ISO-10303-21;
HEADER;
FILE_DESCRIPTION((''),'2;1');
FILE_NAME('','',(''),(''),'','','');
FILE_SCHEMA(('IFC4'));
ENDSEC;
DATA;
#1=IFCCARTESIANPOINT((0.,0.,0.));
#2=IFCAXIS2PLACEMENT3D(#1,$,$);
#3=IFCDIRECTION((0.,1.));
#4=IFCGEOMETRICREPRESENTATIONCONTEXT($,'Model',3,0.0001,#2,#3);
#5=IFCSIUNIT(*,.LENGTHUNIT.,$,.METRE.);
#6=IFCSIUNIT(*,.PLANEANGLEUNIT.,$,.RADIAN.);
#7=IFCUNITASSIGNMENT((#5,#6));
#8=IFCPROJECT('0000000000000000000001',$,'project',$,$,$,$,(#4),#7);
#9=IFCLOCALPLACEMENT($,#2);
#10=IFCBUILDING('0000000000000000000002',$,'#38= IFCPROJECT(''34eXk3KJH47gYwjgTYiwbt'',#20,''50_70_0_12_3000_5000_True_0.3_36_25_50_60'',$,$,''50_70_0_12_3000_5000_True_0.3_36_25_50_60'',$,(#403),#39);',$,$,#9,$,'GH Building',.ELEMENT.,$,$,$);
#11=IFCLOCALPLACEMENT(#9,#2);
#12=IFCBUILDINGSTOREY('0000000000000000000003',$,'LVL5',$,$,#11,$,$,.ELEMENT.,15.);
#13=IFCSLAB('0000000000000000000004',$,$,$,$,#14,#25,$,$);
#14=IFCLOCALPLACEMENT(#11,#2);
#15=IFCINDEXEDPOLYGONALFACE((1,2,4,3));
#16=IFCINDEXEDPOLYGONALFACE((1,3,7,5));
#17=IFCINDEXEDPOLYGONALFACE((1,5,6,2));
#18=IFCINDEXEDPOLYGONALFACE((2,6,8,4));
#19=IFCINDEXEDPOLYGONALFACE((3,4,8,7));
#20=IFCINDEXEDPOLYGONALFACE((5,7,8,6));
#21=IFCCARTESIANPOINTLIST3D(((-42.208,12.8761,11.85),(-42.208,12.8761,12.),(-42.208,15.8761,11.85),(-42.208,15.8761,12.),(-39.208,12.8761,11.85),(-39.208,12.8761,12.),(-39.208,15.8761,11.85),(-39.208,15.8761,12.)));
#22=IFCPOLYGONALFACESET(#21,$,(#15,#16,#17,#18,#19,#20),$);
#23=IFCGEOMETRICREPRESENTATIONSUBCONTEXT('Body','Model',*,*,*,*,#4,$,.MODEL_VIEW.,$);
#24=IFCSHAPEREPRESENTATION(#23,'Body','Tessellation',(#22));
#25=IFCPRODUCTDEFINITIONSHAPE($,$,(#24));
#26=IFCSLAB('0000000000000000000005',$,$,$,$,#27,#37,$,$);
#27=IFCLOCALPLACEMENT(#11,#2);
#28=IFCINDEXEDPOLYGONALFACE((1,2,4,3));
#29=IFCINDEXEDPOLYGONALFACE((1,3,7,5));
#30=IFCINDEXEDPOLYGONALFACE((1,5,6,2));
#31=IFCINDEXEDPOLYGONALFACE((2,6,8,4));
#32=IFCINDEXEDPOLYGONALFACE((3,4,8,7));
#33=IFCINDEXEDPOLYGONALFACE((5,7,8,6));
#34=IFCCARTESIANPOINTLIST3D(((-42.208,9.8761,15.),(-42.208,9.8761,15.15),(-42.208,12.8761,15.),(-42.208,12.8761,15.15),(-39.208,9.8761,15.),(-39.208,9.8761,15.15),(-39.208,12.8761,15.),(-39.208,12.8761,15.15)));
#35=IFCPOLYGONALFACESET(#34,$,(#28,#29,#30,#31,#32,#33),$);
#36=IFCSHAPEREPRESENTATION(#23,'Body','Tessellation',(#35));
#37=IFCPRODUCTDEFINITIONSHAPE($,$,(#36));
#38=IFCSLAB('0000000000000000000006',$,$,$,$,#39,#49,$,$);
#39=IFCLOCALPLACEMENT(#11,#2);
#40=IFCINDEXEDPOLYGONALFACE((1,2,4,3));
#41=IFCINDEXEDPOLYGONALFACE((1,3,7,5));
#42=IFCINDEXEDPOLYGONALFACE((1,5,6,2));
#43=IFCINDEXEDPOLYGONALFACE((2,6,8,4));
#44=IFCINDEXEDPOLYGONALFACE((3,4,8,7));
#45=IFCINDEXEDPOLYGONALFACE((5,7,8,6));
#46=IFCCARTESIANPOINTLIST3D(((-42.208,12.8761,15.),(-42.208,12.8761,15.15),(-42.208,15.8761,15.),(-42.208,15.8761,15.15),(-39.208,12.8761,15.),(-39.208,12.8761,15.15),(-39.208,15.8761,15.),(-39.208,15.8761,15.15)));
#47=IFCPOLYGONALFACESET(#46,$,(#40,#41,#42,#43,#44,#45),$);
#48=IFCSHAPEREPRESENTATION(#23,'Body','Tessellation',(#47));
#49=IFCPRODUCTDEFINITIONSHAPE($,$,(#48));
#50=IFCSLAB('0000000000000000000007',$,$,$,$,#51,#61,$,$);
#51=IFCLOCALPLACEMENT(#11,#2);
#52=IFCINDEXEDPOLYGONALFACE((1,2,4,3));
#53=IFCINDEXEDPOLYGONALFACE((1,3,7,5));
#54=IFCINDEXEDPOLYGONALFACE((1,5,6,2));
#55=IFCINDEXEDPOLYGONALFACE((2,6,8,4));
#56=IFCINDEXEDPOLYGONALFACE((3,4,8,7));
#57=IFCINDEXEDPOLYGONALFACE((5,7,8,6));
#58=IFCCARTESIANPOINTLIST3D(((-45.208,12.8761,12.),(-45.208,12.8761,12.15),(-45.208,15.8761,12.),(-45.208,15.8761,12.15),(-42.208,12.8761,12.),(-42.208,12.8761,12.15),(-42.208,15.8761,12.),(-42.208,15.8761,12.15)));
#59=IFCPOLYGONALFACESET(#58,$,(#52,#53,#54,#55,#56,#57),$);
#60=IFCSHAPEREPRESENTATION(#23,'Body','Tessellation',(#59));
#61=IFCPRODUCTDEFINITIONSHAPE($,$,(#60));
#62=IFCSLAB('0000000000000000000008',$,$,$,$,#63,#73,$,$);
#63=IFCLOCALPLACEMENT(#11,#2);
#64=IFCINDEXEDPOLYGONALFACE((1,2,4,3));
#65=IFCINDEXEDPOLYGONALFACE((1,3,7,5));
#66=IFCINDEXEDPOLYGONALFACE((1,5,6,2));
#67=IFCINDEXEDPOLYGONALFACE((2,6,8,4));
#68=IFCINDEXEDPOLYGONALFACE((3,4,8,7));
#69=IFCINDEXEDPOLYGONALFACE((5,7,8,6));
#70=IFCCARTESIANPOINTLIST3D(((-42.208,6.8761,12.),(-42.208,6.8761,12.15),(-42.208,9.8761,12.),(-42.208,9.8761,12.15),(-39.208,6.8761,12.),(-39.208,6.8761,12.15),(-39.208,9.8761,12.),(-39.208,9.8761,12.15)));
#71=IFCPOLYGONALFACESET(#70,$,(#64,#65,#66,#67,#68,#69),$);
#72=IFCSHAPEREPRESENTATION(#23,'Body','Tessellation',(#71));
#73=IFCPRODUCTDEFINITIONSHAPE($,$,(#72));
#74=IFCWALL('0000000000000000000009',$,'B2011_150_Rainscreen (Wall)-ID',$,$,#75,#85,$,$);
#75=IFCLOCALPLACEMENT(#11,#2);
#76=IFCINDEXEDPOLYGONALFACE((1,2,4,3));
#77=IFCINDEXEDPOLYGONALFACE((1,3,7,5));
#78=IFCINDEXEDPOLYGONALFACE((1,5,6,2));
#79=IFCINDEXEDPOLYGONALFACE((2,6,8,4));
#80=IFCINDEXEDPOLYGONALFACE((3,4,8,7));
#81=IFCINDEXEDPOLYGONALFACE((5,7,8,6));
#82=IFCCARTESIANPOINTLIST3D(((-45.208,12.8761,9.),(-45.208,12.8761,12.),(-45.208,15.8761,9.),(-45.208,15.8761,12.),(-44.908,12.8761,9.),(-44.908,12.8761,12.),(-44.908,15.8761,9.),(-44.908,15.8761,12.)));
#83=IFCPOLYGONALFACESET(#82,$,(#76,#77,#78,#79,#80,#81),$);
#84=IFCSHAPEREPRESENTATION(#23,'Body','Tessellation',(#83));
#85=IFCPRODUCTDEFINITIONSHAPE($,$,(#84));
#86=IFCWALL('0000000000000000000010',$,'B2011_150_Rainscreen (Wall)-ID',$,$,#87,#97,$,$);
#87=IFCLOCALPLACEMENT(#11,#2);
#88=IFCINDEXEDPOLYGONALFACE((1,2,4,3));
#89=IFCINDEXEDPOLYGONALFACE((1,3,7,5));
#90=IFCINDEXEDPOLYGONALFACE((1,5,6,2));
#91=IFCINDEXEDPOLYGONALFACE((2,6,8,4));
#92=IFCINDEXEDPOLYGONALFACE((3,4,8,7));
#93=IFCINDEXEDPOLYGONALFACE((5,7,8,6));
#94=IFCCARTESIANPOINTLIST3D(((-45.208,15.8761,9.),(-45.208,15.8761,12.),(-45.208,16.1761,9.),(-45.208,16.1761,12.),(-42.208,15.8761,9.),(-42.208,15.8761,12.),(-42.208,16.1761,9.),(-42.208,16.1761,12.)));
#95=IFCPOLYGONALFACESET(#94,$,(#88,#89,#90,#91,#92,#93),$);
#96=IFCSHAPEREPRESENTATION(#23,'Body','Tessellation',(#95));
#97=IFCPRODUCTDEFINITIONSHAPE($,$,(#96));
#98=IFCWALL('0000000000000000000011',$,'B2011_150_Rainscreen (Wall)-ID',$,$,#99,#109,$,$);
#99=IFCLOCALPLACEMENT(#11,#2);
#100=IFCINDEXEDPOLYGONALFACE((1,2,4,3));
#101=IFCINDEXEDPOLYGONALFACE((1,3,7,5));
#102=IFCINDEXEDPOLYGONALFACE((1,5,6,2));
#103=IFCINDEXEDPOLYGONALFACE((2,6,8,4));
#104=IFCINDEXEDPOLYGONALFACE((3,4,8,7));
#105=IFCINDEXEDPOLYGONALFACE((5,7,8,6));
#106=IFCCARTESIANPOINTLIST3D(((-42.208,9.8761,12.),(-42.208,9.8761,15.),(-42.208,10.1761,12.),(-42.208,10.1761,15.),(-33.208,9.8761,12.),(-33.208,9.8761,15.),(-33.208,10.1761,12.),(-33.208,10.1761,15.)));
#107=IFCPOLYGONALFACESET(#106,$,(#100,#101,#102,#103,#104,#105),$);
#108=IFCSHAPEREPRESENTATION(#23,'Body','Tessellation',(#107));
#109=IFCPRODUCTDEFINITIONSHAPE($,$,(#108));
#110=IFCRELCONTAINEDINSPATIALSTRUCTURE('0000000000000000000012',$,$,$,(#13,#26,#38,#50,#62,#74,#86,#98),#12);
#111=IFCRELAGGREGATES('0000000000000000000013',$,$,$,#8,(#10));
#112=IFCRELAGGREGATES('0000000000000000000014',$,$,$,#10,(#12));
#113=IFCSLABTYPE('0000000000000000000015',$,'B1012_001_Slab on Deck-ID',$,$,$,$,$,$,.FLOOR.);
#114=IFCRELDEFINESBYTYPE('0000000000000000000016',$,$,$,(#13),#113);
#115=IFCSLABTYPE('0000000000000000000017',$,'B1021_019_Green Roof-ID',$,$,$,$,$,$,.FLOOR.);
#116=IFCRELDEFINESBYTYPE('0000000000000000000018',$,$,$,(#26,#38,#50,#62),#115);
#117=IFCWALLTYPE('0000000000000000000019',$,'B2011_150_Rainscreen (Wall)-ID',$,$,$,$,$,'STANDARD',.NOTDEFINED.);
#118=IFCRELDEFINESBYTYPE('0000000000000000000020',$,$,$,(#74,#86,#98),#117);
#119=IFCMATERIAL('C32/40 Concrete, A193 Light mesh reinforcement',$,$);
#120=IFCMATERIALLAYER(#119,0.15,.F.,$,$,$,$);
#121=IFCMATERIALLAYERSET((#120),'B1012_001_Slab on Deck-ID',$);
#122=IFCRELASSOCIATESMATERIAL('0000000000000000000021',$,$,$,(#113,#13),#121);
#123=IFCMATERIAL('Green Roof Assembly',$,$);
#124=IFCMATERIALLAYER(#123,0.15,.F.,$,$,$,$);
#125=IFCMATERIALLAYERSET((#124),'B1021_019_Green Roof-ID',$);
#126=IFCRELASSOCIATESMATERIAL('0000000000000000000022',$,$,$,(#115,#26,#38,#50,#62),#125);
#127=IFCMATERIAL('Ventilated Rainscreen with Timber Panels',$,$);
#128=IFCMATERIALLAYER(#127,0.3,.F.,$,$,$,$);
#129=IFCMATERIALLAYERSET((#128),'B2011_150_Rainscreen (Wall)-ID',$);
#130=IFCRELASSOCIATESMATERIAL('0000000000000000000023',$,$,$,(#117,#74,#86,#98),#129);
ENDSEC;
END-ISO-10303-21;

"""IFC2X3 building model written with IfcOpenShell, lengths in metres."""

from ifc_helpers import new_model, si_unit, direction, frame, frame_2d, origin, place, context, subcontext, project, spatial, polyline, rectangle, outline, extrude, material, layer, layer_set, layer_usage, type_object, element, save


model = new_model("IFC2X3")

# Units and contexts
model_context = context("Model", 3, precision=0.0001, world=origin(), true_north=direction((0.0, 1.0)))
body_context = subcontext(model_context, "Body", "Model", "MODEL_VIEW")
ifc_project = project(units=[si_unit("LENGTHUNIT", "METRE"), si_unit("PLANEANGLEUNIT", "RADIAN")], contexts=[model_context])

# Building, storey
building_placement = place(None, origin())
building = spatial("IfcBuilding", under=ifc_project, at=building_placement, Name="#38= IFCPROJECT('34eXk3KJH47gYwjgTYiwbt',#20,'50_70_0_12_3000_5000_True_0.3_36_25_50_60',$,$,'50_70_0_12_3000_5000_True_0.3_36_25_50_60',$,(#403),#39);", LongName="GH Building", CompositionType="ELEMENT")
storey_placement = place(building_placement, origin())
storey = spatial("IfcBuildingStorey", under=building, at=storey_placement, Name="LVL5", CompositionType="ELEMENT", Elevation=15.0)

# Slabs
ifc_material_1 = material(Name="C32/40 Concrete, A193 Light mesh reinforcement")
ifc_layer_1 = layer(ifc_material_1, 0.15, ventilated=False)
ifc_layer_set_1 = layer_set([ifc_layer_1], Name="B1012_001_Slab on Deck-ID")
slab_type_1 = type_object("IfcSlabType", Name="B1012_001_Slab on Deck-ID", PredefinedType="FLOOR", material=ifc_layer_set_1)
ifc_layer_usage_1 = layer_usage(ifc_layer_set_1, "AXIS3", "NEGATIVE", -0.15)
slab_1_placement = place(storey_placement, frame((-40.708, 14.3761, 11.85)))
element("IfcSlab", 1, at=slab_1_placement, inside=storey, type_object=slab_type_1, material=ifc_layer_usage_1, context=body_context, shape_type="SweptSolid", body=[
    extrude(outline(polyline([(-1.5, 1.5), (1.5, 1.5), (1.5, -1.5), (-1.5, -1.5), (-1.5, 1.5)])), origin(), (0.0, 0.0, 1.0), 0.15),
])
ifc_material_2 = material(Name="Green Roof Assembly")
ifc_layer_2 = layer(ifc_material_2, 0.15, ventilated=False)
ifc_layer_set_2 = layer_set([ifc_layer_2], Name="B1021_019_Green Roof-ID")
ifc_layer_usage_2 = layer_usage(ifc_layer_set_2, "AXIS3", "NEGATIVE", -0.15)
slab_type_2 = type_object("IfcSlabType", Name="B1021_019_Green Roof-ID", PredefinedType="FLOOR", material=ifc_layer_set_2)
slab_2_placement = place(storey_placement, frame((-40.708, 11.3761, 15.0)))
element("IfcSlab", 2, at=slab_2_placement, inside=storey, type_object=slab_type_2, material=ifc_layer_usage_2, context=body_context, shape_type="SweptSolid", body=[
    extrude(outline(polyline([(-1.5, -1.5), (-1.5, 1.5), (1.5, 1.5), (1.5, -1.5), (-1.5, -1.5)])), origin(), (0.0, 0.0, 1.0), 0.15),
])
ifc_layer_usage_3 = layer_usage(ifc_layer_set_2, "AXIS3", "NEGATIVE", -0.15)
slab_3_placement = place(storey_placement, frame((-40.708, 14.3761, 15.0)))
element("IfcSlab", 3, at=slab_3_placement, inside=storey, type_object=slab_type_2, material=ifc_layer_usage_3, context=body_context, shape_type="SweptSolid", body=[
    extrude(outline(polyline([(-1.5, -1.5), (-1.5, 1.5), (1.5, 1.5), (1.5, -1.5), (-1.5, -1.5)])), origin(), (0.0, 0.0, 1.0), 0.15),
])
ifc_layer_usage_4 = layer_usage(ifc_layer_set_2, "AXIS3", "NEGATIVE", -0.15)
slab_4_placement = place(storey_placement, frame((-43.708, 14.3761, 12.0)))
element("IfcSlab", 4, at=slab_4_placement, inside=storey, type_object=slab_type_2, material=ifc_layer_usage_4, context=body_context, shape_type="SweptSolid", body=[
    extrude(outline(polyline([(-1.5, 1.5), (1.5, 1.5), (1.5, -1.5), (-1.5, -1.5), (-1.5, 1.5)])), origin(), (0.0, 0.0, 1.0), 0.15),
])
ifc_layer_usage_5 = layer_usage(ifc_layer_set_2, "AXIS3", "NEGATIVE", -0.15)
slab_5_placement = place(storey_placement, frame((-40.708, 8.3761, 12.0)))
element("IfcSlab", 5, at=slab_5_placement, inside=storey, type_object=slab_type_2, material=ifc_layer_usage_5, context=body_context, shape_type="SweptSolid", body=[
    extrude(outline(polyline([(1.5, 1.5), (1.5, -1.5), (-1.5, -1.5), (-1.5, 1.5), (1.5, 1.5)])), origin(), (0.0, 0.0, 1.0), 0.15),
])

# Walls
ifc_material_3 = material(Name="Ventilated Rainscreen with Timber Panels")
ifc_layer_3 = layer(ifc_material_3, 0.3, ventilated=False)
ifc_layer_set_3 = layer_set([ifc_layer_3], Name="B2011_150_Rainscreen (Wall)-ID")
ifc_layer_usage_6 = layer_usage(ifc_layer_set_3, "AXIS2", "POSITIVE", 0.0)
wall_type = type_object("IfcWallType", Name="B2011_150_Rainscreen (Wall)-ID", ElementType="STANDARD", PredefinedType="NOTDEFINED", material=ifc_layer_set_3)
wall_1_placement = place(storey_placement, frame((-45.208, 15.8761, 9.0), z_axis=(0.0, 0.0, 1.0), x_axis=(0.0, -1.0, 0.0)))
element("IfcWall", 6, at=wall_1_placement, inside=storey, type_object=wall_type, material=ifc_layer_usage_6, Name="B2011_150_Rainscreen (Wall)-ID", context=body_context, shape_type="SweptSolid", body=[
    extrude(rectangle(XDim=3.0, YDim=0.3, at=frame_2d((1.5, 0.15))), origin(), (0.0, 0.0, 1.0), 3.0),
])
ifc_layer_usage_7 = layer_usage(ifc_layer_set_3, "AXIS2", "POSITIVE", 0.0)
wall_2_placement = place(storey_placement, frame((-45.208, 15.8761, 9.0)))
element("IfcWall", 7, at=wall_2_placement, inside=storey, type_object=wall_type, material=ifc_layer_usage_7, Name="B2011_150_Rainscreen (Wall)-ID", context=body_context, shape_type="SweptSolid", body=[
    extrude(rectangle(XDim=3.0, YDim=0.3, at=frame_2d((1.5, 0.15))), origin(), (0.0, 0.0, 1.0), 3.0),
])
ifc_layer_usage_8 = layer_usage(ifc_layer_set_3, "AXIS2", "POSITIVE", 0.0)
wall_3_placement = place(storey_placement, frame((-42.208, 9.8761, 12.0)))
element("IfcWall", 8, at=wall_3_placement, inside=storey, type_object=wall_type, material=ifc_layer_usage_8, Name="B2011_150_Rainscreen (Wall)-ID", context=body_context, shape_type="SweptSolid", body=[
    extrude(rectangle(XDim=9.0, YDim=0.3, at=frame_2d((4.5, 0.15))), origin(), (0.0, 0.0, 1.0), 3.0),
])

save(model, "model.ifc")
